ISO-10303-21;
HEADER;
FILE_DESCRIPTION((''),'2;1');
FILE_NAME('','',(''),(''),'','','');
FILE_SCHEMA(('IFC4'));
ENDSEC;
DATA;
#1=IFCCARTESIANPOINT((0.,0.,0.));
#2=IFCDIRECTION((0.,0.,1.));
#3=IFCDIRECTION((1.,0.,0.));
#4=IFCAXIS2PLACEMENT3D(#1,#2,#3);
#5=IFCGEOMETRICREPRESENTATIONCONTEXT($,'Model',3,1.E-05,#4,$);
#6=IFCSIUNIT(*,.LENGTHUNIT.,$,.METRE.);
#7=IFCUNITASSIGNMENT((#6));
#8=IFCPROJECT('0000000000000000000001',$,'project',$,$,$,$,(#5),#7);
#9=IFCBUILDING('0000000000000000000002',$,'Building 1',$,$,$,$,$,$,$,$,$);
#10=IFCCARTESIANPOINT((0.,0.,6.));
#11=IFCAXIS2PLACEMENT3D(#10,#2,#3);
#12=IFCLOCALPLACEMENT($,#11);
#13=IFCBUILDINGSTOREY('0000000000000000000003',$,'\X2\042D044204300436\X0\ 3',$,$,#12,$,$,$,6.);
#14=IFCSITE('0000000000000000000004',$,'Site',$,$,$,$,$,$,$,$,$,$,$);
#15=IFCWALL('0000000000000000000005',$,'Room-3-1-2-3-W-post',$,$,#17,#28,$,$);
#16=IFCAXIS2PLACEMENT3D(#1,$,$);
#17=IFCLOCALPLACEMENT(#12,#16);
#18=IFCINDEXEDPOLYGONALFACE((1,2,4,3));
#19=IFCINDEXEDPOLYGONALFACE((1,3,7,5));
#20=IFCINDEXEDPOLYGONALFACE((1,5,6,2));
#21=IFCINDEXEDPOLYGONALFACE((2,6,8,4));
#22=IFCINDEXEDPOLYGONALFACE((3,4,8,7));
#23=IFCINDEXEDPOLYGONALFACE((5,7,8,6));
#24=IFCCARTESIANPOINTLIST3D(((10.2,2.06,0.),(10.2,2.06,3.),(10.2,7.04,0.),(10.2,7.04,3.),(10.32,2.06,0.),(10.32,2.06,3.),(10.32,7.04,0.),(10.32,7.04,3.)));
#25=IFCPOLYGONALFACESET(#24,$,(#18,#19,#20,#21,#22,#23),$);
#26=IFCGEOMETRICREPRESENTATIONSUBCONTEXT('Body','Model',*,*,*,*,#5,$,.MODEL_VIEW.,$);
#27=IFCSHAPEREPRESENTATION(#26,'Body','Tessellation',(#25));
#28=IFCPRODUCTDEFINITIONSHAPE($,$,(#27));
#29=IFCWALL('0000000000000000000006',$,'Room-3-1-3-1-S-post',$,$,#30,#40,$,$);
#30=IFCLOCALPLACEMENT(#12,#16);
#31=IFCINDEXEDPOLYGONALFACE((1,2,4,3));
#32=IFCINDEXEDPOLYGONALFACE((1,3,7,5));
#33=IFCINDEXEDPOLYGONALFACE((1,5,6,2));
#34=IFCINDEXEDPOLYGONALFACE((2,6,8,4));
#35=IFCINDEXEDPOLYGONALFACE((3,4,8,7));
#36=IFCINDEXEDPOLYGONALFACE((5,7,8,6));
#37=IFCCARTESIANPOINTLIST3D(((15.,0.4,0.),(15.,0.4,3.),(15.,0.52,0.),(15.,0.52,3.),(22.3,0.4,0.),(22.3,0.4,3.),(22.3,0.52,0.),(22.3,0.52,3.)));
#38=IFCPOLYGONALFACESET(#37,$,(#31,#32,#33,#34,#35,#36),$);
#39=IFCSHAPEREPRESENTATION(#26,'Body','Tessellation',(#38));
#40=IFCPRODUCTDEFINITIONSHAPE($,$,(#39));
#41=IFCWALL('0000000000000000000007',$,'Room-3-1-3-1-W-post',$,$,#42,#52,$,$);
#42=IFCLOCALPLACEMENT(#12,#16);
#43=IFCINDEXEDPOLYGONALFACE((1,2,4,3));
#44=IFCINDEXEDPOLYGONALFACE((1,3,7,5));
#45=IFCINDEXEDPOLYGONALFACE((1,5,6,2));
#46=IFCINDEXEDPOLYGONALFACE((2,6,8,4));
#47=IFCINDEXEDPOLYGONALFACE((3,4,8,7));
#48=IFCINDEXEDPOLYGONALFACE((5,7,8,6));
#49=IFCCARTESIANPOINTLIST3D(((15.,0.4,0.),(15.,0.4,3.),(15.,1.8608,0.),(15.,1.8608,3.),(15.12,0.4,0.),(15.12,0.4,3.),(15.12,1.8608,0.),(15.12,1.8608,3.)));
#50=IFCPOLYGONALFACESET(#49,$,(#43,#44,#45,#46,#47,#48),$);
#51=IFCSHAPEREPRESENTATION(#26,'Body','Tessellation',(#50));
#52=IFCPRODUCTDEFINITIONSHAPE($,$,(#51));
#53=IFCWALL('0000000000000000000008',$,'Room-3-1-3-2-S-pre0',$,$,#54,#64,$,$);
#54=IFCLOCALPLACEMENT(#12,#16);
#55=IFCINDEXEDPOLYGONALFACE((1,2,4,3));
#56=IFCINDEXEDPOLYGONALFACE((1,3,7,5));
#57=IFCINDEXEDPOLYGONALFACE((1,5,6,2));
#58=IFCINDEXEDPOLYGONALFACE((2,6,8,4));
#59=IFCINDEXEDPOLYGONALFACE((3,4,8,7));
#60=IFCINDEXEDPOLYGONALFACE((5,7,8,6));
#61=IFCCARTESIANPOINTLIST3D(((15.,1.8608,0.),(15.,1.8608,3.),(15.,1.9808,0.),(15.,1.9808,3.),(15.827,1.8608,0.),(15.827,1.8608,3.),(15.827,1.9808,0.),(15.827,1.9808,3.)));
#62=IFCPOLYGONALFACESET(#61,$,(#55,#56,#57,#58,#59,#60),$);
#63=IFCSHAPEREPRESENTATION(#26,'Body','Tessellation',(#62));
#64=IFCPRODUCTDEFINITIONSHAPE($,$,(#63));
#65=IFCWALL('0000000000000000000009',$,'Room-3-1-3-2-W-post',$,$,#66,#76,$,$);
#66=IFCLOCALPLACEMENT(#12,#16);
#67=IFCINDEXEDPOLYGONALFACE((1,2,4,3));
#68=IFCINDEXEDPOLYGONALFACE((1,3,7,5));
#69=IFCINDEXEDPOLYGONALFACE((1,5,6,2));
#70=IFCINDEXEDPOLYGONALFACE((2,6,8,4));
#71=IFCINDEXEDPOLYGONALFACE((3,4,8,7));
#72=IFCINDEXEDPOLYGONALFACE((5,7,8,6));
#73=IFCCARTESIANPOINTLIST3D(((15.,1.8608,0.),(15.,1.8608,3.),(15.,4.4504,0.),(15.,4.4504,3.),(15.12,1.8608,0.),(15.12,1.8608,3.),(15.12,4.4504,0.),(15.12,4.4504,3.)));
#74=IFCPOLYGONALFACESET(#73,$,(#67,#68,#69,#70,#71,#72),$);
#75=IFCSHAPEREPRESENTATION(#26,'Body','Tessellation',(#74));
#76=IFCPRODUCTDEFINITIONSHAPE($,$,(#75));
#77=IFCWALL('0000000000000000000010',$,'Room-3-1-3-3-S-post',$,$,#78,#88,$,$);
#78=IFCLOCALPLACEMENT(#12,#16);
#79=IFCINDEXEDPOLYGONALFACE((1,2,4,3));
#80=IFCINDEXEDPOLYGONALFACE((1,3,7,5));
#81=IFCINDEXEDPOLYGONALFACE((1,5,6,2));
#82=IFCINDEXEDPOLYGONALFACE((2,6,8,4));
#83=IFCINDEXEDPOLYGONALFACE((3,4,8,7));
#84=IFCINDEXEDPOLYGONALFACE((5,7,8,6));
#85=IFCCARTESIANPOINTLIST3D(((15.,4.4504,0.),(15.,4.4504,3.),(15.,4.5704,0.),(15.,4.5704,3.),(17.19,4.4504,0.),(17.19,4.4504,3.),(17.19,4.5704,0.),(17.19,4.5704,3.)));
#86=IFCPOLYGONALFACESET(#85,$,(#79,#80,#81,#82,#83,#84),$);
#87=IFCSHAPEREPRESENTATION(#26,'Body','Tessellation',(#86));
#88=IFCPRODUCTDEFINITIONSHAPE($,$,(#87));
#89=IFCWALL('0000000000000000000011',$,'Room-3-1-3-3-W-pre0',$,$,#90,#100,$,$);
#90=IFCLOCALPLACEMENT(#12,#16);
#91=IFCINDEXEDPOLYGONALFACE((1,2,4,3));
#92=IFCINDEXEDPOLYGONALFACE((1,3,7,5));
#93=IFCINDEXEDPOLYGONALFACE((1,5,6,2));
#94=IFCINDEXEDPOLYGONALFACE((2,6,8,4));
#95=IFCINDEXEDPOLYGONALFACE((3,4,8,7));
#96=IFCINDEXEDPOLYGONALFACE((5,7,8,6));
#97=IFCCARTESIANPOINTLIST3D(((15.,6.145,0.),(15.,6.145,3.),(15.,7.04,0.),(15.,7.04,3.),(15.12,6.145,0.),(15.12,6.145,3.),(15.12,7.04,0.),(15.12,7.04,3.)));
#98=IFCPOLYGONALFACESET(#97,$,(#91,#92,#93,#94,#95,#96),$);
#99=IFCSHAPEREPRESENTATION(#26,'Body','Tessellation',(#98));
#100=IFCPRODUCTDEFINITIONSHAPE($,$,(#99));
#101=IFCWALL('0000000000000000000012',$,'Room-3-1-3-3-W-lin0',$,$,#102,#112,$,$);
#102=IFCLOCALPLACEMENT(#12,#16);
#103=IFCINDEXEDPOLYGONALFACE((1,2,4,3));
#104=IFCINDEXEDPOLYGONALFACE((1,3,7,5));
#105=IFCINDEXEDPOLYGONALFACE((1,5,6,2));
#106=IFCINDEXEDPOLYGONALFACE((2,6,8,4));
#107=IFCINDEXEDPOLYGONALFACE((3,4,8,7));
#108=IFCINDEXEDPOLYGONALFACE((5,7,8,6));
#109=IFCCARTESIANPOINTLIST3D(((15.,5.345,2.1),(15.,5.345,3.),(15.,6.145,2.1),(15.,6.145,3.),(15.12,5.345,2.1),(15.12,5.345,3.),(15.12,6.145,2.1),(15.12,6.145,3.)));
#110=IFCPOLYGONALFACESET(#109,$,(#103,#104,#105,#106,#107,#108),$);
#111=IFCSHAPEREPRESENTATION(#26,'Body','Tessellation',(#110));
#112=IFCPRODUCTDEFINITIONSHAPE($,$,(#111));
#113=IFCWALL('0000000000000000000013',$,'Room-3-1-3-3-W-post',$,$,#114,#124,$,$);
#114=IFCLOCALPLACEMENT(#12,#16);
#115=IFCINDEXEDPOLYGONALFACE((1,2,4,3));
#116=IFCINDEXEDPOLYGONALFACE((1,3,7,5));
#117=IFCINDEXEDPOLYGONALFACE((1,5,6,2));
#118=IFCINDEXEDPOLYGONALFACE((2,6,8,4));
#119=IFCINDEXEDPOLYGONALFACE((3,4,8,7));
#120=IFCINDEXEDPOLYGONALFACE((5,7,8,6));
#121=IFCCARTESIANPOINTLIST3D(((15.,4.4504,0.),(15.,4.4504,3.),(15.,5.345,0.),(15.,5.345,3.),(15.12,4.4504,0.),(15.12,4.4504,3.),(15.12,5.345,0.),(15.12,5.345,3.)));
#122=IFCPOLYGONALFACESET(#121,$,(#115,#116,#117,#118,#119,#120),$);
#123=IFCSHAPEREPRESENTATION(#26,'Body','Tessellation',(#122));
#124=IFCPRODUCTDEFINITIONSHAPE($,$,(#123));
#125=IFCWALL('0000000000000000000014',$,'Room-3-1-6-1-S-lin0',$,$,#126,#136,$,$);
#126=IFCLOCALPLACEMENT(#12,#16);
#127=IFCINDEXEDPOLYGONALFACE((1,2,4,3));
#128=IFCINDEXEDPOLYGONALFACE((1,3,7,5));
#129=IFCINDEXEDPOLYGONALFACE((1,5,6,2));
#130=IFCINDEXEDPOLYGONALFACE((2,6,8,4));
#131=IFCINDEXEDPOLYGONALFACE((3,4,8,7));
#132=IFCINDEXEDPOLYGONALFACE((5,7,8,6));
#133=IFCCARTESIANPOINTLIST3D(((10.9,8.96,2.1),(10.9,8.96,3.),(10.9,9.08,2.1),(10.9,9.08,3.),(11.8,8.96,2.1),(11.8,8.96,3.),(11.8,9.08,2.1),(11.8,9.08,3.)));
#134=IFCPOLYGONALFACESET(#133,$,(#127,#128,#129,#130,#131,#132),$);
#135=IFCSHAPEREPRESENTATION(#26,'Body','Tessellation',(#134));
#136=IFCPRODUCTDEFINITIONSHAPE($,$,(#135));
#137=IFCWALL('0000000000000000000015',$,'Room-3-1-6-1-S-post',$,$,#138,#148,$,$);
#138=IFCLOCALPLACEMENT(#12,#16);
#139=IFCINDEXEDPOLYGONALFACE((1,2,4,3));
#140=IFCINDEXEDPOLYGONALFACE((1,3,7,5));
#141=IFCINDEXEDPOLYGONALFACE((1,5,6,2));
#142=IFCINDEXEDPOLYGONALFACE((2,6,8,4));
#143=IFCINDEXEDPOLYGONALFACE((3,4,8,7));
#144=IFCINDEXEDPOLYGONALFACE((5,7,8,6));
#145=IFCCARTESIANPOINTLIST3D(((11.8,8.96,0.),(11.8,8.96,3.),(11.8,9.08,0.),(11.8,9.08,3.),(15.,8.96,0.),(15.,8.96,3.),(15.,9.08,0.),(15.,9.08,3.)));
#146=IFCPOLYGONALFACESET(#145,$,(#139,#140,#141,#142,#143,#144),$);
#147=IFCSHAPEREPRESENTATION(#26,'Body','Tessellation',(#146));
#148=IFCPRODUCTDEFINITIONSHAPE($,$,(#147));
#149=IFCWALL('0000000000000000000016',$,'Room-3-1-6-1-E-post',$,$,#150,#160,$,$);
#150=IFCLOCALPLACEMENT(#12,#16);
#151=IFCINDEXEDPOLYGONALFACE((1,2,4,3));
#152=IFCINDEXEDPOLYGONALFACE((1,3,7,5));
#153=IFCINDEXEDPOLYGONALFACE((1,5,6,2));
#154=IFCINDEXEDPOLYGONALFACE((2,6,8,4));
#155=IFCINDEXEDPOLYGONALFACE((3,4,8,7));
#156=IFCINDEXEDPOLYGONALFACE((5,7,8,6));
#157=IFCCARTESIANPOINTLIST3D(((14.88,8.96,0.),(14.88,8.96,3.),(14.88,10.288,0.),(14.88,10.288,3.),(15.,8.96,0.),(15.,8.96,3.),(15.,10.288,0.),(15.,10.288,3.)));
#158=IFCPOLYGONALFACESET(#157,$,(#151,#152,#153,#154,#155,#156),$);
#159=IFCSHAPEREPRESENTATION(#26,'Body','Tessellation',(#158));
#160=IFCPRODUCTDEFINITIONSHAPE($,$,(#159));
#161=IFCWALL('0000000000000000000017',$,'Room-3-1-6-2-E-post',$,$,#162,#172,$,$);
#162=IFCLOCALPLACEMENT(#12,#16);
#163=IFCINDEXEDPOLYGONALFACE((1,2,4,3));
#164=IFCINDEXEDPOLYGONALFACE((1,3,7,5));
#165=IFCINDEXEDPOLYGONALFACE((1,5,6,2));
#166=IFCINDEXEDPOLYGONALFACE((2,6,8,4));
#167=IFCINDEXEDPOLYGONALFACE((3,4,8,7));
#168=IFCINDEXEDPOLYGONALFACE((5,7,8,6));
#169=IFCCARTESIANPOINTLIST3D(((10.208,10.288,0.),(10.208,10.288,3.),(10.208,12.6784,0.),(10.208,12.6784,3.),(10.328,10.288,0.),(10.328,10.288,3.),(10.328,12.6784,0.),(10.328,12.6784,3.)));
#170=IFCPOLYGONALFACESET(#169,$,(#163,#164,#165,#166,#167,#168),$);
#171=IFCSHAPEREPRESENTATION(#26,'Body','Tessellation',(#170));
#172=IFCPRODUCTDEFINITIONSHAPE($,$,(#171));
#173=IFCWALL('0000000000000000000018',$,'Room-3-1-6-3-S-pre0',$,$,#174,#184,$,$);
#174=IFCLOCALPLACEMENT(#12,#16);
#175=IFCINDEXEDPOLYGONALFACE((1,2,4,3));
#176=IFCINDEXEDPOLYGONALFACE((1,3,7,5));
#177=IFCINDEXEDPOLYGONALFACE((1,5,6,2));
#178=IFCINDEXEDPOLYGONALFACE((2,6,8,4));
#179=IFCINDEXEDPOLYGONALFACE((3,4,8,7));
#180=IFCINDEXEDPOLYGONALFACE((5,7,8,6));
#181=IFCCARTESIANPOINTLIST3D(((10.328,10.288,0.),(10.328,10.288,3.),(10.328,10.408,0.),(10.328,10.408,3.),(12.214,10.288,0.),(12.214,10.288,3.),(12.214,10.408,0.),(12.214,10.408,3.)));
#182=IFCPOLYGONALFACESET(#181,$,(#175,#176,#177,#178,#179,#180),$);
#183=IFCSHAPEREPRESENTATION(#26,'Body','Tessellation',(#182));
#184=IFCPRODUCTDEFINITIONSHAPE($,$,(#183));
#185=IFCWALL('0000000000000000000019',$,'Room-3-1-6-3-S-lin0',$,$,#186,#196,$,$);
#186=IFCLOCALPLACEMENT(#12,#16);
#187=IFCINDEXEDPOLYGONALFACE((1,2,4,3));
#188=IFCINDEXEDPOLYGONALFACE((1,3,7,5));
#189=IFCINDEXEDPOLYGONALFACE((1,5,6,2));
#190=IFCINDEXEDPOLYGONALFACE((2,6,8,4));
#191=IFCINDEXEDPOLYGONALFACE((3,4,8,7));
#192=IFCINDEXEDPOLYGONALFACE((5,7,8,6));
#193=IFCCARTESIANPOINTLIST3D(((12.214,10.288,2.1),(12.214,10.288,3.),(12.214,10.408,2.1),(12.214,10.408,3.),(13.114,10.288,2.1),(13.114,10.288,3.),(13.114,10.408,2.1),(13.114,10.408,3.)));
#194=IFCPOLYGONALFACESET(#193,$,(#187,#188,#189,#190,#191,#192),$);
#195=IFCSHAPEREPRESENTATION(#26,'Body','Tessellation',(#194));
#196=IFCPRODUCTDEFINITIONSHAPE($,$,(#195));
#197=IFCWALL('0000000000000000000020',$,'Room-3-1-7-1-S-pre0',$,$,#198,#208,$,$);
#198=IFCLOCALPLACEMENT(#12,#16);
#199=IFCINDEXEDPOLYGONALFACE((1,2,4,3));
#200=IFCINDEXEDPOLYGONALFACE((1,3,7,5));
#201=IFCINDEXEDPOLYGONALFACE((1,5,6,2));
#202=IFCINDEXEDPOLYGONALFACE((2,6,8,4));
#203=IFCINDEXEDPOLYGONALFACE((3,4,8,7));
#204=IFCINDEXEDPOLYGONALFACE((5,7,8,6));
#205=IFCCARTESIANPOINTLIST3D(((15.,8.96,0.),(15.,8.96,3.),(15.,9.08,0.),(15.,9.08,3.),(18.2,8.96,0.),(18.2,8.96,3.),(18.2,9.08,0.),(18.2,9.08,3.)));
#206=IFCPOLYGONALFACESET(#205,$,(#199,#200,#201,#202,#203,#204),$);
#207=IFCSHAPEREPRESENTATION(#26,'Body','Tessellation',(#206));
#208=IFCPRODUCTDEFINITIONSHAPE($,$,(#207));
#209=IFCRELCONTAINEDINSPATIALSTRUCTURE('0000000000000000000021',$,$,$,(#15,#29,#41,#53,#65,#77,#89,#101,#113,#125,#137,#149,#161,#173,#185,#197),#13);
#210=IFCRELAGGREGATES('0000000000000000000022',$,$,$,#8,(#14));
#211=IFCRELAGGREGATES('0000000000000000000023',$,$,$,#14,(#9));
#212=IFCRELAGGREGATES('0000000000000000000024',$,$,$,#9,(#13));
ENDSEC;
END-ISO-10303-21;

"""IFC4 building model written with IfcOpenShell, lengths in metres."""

from ifc_helpers import new_model, si_unit, frame, origin_with_axes, place, context, subcontext, project, spatial, indexed_curve, outline, extrude, element, save


model = new_model("IFC4")

# Units and contexts
model_context = context("Model", 3, precision=1e-05, world=origin_with_axes())
body_context = subcontext(model_context, "Body", "Model", "MODEL_VIEW")
ifc_project = project(units=[si_unit("LENGTHUNIT", "METRE")], contexts=[model_context])

# Site, building, storey
site = spatial("IfcSite", under=ifc_project, Name="Site")
building = spatial("IfcBuilding", under=site, Name="Building 1")
storey_placement = place(None, frame((0.0, 0.0, 6.0), z_axis=(0.0, 0.0, 1.0), x_axis=(1.0, 0.0, 0.0)))
storey = spatial("IfcBuildingStorey", under=building, at=storey_placement, Name="Этаж 3", Elevation=6.0)

# Walls
wall_1_placement = place(storey_placement, frame((10.2, 7.04, 0.0), z_axis=(0.0, 0.0, 1.0), x_axis=(0.0, -1.0, 0.0)))
element("IfcWall", 1, at=wall_1_placement, inside=storey, Name="Room-3-1-2-3-W-post", context=body_context, shape_type="SweptSolid", body=[
    extrude(outline(indexed_curve([(0.0, 0.0), (0.0, 0.12), (4.98, 0.12), (4.98, 0.0), (0.0, 0.0)], self_intersect=False)), origin_with_axes(), (0.0, 0.0, 1.0), 3.0),
])
wall_2_placement = place(storey_placement, frame((15.0, 0.4, 0.0), z_axis=(0.0, 0.0, 1.0), x_axis=(1.0, 0.0, 0.0)))
element("IfcWall", 2, at=wall_2_placement, inside=storey, Name="Room-3-1-3-1-S-post", context=body_context, shape_type="SweptSolid", body=[
    extrude(outline(indexed_curve([(0.0, 0.0), (0.0, 0.12), (7.3, 0.12), (7.3, 0.0), (0.0, 0.0)], self_intersect=False)), origin_with_axes(), (0.0, 0.0, 1.0), 3.0),
])
wall_3_placement = place(storey_placement, frame((15.0, 1.8608, 0.0), z_axis=(0.0, 0.0, 1.0), x_axis=(0.0, -1.0, 0.0)))
element("IfcWall", 3, at=wall_3_placement, inside=storey, Name="Room-3-1-3-1-W-post", context=body_context, shape_type="SweptSolid", body=[
    extrude(outline(indexed_curve([(0.0, 0.0), (0.0, 0.12), (1.4608, 0.12), (1.4608, 0.0), (0.0, 0.0)], self_intersect=False)), origin_with_axes(), (0.0, 0.0, 1.0), 3.0),
])
wall_4_placement = place(storey_placement, frame((15.0, 1.8608, 0.0), z_axis=(0.0, 0.0, 1.0), x_axis=(1.0, 0.0, 0.0)))
element("IfcWall", 4, at=wall_4_placement, inside=storey, Name="Room-3-1-3-2-S-pre0", context=body_context, shape_type="SweptSolid", body=[
    extrude(outline(indexed_curve([(0.0, 0.0), (0.0, 0.12), (0.827, 0.12), (0.827, 0.0), (0.0, 0.0)], self_intersect=False)), origin_with_axes(), (0.0, 0.0, 1.0), 3.0),
])
wall_5_placement = place(storey_placement, frame((15.0, 4.4504, 0.0), z_axis=(0.0, 0.0, 1.0), x_axis=(0.0, -1.0, 0.0)))
element("IfcWall", 5, at=wall_5_placement, inside=storey, Name="Room-3-1-3-2-W-post", context=body_context, shape_type="SweptSolid", body=[
    extrude(outline(indexed_curve([(0.0, 0.0), (0.0, 0.12), (2.5896, 0.12), (2.5896, 0.0), (0.0, 0.0)], self_intersect=False)), origin_with_axes(), (0.0, 0.0, 1.0), 3.0),
])
wall_6_placement = place(storey_placement, frame((15.0, 4.4504, 0.0), z_axis=(0.0, 0.0, 1.0), x_axis=(1.0, 0.0, 0.0)))
element("IfcWall", 6, at=wall_6_placement, inside=storey, Name="Room-3-1-3-3-S-post", context=body_context, shape_type="SweptSolid", body=[
    extrude(outline(indexed_curve([(0.0, 0.0), (0.0, 0.12), (2.19, 0.12), (2.19, 0.0), (0.0, 0.0)], self_intersect=False)), origin_with_axes(), (0.0, 0.0, 1.0), 3.0),
])
wall_7_placement = place(storey_placement, frame((15.0, 7.04, 0.0), z_axis=(0.0, 0.0, 1.0), x_axis=(0.0, -1.0, 0.0)))
element("IfcWall", 7, at=wall_7_placement, inside=storey, Name="Room-3-1-3-3-W-pre0", context=body_context, shape_type="SweptSolid", body=[
    extrude(outline(indexed_curve([(0.0, 0.0), (0.0, 0.12), (0.895, 0.12), (0.895, 0.0), (0.0, 0.0)], self_intersect=False)), origin_with_axes(), (0.0, 0.0, 1.0), 3.0),
])
wall_8_placement = place(storey_placement, frame((15.0, 6.145, 2.1), z_axis=(0.0, 0.0, 1.0), x_axis=(0.0, -1.0, 0.0)))
element("IfcWall", 8, at=wall_8_placement, inside=storey, Name="Room-3-1-3-3-W-lin0", context=body_context, shape_type="SweptSolid", body=[
    extrude(outline(indexed_curve([(0.0, 0.0), (0.0, 0.12), (0.8, 0.12), (0.8, 0.0), (0.0, 0.0)], self_intersect=False)), origin_with_axes(), (0.0, 0.0, 1.0), 0.9),
])
wall_9_placement = place(storey_placement, frame((15.0, 5.345, 0.0), z_axis=(0.0, 0.0, 1.0), x_axis=(0.0, -1.0, 0.0)))
element("IfcWall", 9, at=wall_9_placement, inside=storey, Name="Room-3-1-3-3-W-post", context=body_context, shape_type="SweptSolid", body=[
    extrude(outline(indexed_curve([(0.0, 0.0), (0.0, 0.12), (0.8946, 0.12), (0.8946, 0.0), (0.0, 0.0)], self_intersect=False)), origin_with_axes(), (0.0, 0.0, 1.0), 3.0),
])
wall_10_placement = place(storey_placement, frame((10.9, 8.96, 2.1), z_axis=(0.0, 0.0, 1.0), x_axis=(1.0, 0.0, 0.0)))
element("IfcWall", 10, at=wall_10_placement, inside=storey, Name="Room-3-1-6-1-S-lin0", context=body_context, shape_type="SweptSolid", body=[
    extrude(outline(indexed_curve([(0.0, 0.0), (0.0, 0.12), (0.9, 0.12), (0.9, 0.0), (0.0, 0.0)], self_intersect=False)), origin_with_axes(), (0.0, 0.0, 1.0), 0.9),
])
wall_11_placement = place(storey_placement, frame((11.8, 8.96, 0.0), z_axis=(0.0, 0.0, 1.0), x_axis=(1.0, 0.0, 0.0)))
element("IfcWall", 11, at=wall_11_placement, inside=storey, Name="Room-3-1-6-1-S-post", context=body_context, shape_type="SweptSolid", body=[
    extrude(outline(indexed_curve([(0.0, 0.0), (0.0, 0.12), (3.2, 0.12), (3.2, 0.0), (0.0, 0.0)], self_intersect=False)), origin_with_axes(), (0.0, 0.0, 1.0), 3.0),
])
wall_12_placement = place(storey_placement, frame((15.0, 8.96, 0.0), z_axis=(0.0, 0.0, 1.0), x_axis=(0.0, 1.0, 0.0)))
element("IfcWall", 12, at=wall_12_placement, inside=storey, Name="Room-3-1-6-1-E-post", context=body_context, shape_type="SweptSolid", body=[
    extrude(outline(indexed_curve([(0.0, 0.0), (0.0, 0.12), (1.328, 0.12), (1.328, 0.0), (0.0, 0.0)], self_intersect=False)), origin_with_axes(), (0.0, 0.0, 1.0), 3.0),
])
wall_13_placement = place(storey_placement, frame((10.328, 10.288, 0.0), z_axis=(0.0, 0.0, 1.0), x_axis=(0.0, 1.0, 0.0)))
element("IfcWall", 13, at=wall_13_placement, inside=storey, Name="Room-3-1-6-2-E-post", context=body_context, shape_type="SweptSolid", body=[
    extrude(outline(indexed_curve([(0.0, 0.0), (0.0, 0.12), (2.3904, 0.12), (2.3904, 0.0), (0.0, 0.0)], self_intersect=False)), origin_with_axes(), (0.0, 0.0, 1.0), 3.0),
])
wall_14_placement = place(storey_placement, frame((10.328, 10.288, 0.0), z_axis=(0.0, 0.0, 1.0), x_axis=(1.0, 0.0, 0.0)))
element("IfcWall", 14, at=wall_14_placement, inside=storey, Name="Room-3-1-6-3-S-pre0", context=body_context, shape_type="SweptSolid", body=[
    extrude(outline(indexed_curve([(0.0, 0.0), (0.0, 0.12), (1.886, 0.12), (1.886, 0.0), (0.0, 0.0)], self_intersect=False)), origin_with_axes(), (0.0, 0.0, 1.0), 3.0),
])
wall_15_placement = place(storey_placement, frame((12.214, 10.288, 2.1), z_axis=(0.0, 0.0, 1.0), x_axis=(1.0, 0.0, 0.0)))
element("IfcWall", 15, at=wall_15_placement, inside=storey, Name="Room-3-1-6-3-S-lin0", context=body_context, shape_type="SweptSolid", body=[
    extrude(outline(indexed_curve([(0.0, 0.0), (0.0, 0.12), (0.9, 0.12), (0.9, 0.0), (0.0, 0.0)], self_intersect=False)), origin_with_axes(), (0.0, 0.0, 1.0), 0.9),
])
wall_16_placement = place(storey_placement, frame((15.0, 8.96, 0.0), z_axis=(0.0, 0.0, 1.0), x_axis=(1.0, 0.0, 0.0)))
element("IfcWall", 16, at=wall_16_placement, inside=storey, Name="Room-3-1-7-1-S-pre0", context=body_context, shape_type="SweptSolid", body=[
    extrude(outline(indexed_curve([(0.0, 0.0), (0.0, 0.12), (3.2, 0.12), (3.2, 0.0), (0.0, 0.0)], self_intersect=False)), origin_with_axes(), (0.0, 0.0, 1.0), 3.0),
])

save(model, "model.ifc")
